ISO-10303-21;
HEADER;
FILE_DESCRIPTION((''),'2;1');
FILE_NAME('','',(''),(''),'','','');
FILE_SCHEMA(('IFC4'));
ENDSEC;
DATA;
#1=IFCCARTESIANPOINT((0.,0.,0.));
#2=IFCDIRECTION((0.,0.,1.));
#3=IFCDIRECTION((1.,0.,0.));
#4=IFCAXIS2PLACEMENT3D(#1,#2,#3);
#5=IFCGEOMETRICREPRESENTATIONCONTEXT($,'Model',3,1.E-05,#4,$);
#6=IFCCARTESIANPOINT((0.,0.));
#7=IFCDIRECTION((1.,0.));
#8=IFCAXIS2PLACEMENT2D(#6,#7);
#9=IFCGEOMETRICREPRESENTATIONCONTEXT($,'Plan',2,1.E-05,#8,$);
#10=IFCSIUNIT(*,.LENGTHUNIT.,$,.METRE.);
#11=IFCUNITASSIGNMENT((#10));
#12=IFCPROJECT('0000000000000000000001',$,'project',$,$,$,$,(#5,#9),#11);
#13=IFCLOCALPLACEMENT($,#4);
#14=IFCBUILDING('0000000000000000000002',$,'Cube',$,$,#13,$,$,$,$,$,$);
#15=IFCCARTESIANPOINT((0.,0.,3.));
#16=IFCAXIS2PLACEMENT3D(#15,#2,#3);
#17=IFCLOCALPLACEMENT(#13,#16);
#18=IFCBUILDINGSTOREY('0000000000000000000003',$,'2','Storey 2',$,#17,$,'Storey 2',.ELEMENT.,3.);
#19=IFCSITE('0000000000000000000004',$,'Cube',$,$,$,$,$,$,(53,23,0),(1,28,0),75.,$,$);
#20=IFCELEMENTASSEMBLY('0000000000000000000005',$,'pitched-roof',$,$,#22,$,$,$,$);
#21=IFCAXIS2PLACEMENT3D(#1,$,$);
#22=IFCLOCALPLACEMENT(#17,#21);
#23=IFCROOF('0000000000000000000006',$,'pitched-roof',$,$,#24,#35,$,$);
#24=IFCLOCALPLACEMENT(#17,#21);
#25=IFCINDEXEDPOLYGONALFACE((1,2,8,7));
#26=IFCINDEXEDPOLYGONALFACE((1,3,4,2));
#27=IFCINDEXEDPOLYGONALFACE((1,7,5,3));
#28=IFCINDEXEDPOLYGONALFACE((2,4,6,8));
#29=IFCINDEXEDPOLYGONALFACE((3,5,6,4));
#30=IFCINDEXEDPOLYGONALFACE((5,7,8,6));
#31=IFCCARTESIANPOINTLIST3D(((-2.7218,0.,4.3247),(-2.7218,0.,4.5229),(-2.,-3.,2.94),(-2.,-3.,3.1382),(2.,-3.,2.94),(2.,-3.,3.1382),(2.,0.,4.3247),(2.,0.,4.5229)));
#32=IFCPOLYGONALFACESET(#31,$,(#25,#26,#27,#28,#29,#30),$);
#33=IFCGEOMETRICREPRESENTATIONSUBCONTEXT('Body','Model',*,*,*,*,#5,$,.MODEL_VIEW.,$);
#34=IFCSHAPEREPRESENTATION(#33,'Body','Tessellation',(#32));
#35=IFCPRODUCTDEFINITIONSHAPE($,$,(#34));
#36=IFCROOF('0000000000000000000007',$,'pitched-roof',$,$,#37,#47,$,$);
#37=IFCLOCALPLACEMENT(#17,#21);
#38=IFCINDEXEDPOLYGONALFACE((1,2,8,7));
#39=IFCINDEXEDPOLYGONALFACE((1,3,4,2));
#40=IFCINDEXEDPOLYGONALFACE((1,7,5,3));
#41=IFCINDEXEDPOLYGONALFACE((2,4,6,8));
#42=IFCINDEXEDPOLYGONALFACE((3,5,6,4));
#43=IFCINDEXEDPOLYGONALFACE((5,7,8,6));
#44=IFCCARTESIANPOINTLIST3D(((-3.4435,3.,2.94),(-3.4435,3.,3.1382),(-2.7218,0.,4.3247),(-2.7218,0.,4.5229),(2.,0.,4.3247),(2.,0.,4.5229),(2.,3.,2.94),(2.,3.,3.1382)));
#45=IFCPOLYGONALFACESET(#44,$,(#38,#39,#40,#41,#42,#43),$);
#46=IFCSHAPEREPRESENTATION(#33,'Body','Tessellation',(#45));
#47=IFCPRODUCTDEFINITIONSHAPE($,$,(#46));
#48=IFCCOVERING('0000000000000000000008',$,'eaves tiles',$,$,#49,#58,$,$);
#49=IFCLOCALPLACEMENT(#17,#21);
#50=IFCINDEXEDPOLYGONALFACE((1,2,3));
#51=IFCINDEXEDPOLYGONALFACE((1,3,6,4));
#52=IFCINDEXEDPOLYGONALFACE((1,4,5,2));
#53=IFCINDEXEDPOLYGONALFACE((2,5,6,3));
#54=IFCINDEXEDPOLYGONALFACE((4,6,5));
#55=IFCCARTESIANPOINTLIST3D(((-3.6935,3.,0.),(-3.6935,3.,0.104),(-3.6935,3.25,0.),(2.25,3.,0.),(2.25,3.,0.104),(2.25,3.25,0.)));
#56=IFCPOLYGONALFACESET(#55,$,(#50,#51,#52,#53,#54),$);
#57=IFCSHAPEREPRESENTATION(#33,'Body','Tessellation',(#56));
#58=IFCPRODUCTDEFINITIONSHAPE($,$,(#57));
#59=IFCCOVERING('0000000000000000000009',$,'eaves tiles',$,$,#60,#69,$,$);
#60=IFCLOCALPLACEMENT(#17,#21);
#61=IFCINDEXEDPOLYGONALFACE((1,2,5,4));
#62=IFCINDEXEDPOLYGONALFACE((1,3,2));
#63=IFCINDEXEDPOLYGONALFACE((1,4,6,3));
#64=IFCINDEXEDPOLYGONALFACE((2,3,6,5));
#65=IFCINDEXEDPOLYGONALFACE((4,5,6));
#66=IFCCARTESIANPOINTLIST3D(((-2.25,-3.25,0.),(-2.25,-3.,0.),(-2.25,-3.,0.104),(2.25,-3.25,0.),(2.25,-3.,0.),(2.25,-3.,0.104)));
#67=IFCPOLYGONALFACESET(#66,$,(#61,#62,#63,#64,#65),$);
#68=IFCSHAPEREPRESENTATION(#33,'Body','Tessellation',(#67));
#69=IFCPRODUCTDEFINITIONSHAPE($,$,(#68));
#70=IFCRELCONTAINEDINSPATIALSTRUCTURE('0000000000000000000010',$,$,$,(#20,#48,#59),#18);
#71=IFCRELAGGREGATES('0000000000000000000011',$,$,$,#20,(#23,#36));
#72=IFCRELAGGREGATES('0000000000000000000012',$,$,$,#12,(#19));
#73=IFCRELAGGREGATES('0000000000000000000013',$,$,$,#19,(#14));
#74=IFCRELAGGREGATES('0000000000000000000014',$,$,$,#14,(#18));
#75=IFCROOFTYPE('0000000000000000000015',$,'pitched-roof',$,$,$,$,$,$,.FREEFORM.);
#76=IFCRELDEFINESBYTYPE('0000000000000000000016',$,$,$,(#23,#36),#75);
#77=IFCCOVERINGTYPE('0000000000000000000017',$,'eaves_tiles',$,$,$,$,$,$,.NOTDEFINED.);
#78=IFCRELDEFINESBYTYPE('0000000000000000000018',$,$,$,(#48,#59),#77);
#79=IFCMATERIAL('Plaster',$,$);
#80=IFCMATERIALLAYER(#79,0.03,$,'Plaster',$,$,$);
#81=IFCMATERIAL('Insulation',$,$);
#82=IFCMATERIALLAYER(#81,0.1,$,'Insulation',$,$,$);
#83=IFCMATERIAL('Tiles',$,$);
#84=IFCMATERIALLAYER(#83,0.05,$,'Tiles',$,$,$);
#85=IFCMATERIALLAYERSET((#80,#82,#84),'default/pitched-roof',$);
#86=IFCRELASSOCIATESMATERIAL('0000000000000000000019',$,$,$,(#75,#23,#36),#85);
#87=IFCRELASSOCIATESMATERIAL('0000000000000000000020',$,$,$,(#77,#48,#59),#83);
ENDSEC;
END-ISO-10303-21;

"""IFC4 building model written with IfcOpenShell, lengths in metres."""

from ifc_helpers import new_model, si_unit, frame, origin, origin_with_axes, origin_2d_with_axis, place, context, subcontext, project, spatial, polyline, outline, extrude, material, layer, layer_set, layer_usage, material_profile, profile_set, profile_usage, type_object, element, aggregate, save


model = new_model("IFC4")

# Units and contexts
model_context = context("Model", 3, precision=1e-05, world=origin_with_axes())
plan_context = context("Plan", 2, precision=1e-05, world=origin_2d_with_axis())
body_context = subcontext(model_context, "Body", "Model", "MODEL_VIEW")
ifc_project = project(units=[si_unit("LENGTHUNIT", "METRE")], contexts=[model_context, plan_context])

# Site, building, storey
site = spatial("IfcSite", under=ifc_project, Name="Cube", RefLatitude=(53, 23, 0), RefLongitude=(1, 28, 0), RefElevation=75.0)
building_placement = place(None, origin_with_axes())
building = spatial("IfcBuilding", under=site, at=building_placement, Name="Cube")
storey_placement = place(building_placement, frame((0.0, 0.0, 3.0), z_axis=(0.0, 0.0, 1.0), x_axis=(1.0, 0.0, 0.0)))
storey = spatial("IfcBuildingStorey", under=building, at=storey_placement, Name="2", Description="Storey 2", LongName="Storey 2", CompositionType="ELEMENT", Elevation=3.0)

# Element assembly, roofs
assembly_placement = place(storey_placement, origin_with_axes())
assembly = element("IfcElementAssembly", 1, at=assembly_placement, inside=storey, Name="pitched-roof")
ifc_material_1 = material(Name="Plaster")
ifc_layer_1 = layer(ifc_material_1, 0.03, Name="Plaster")
ifc_material_2 = material(Name="Insulation")
ifc_layer_2 = layer(ifc_material_2, 0.1, Name="Insulation")
ifc_material_3 = material(Name="Tiles")
ifc_layer_3 = layer(ifc_material_3, 0.05, Name="Tiles")
ifc_layer_set = layer_set([ifc_layer_1, ifc_layer_2, ifc_layer_3], Name="default/pitched-roof")
ifc_layer_usage_1 = layer_usage(ifc_layer_set, "AXIS3", "POSITIVE", 0.0)
roof_type = type_object("IfcRoofType", Name="pitched-roof", PredefinedType="FREEFORM", material=ifc_layer_set)
roof_1_placement = place(assembly_placement, frame((-2.0, -3.0, 2.94), z_axis=(0.0, -0.419069, 0.907954), x_axis=(1.0, 0.0, 0.0)))
roof_1 = element("IfcRoof", 2, at=roof_1_placement, type_object=roof_type, material=ifc_layer_usage_1, Name="pitched-roof", context=body_context, shape_type="SweptSolid", body=[
    extrude(outline(polyline([(0.0, 0.0), (4.0, 0.0), (4.0, 3.3041), (-0.7218, 3.3041), (0.0, 0.0)])), origin(), (0.0, 0.419069, 0.907954), 0.1982),
])
ifc_layer_usage_2 = layer_usage(ifc_layer_set, "AXIS3", "POSITIVE", 0.0)
roof_2_placement = place(assembly_placement, frame((-3.4435, 3.0, 2.94), z_axis=(0.0, 0.419069, 0.907954), x_axis=(-1.0, 0.0, 0.0)))
roof_2 = element("IfcRoof", 3, at=roof_2_placement, type_object=roof_type, material=ifc_layer_usage_2, Name="pitched-roof", context=body_context, shape_type="SweptSolid", body=[
    extrude(outline(polyline([(0.0, 0.0), (-0.7218, 3.3041), (-5.4435, 3.3041), (-5.4435, 0.0), (0.0, 0.0)])), origin(), (0.0, 0.419069, 0.907954), 0.1982),
])
aggregate(assembly, [roof_1, roof_2])

# Coverings
ifc_material_profile_1 = material_profile(ifc_material_3, outline(polyline([(0.25, 0.0), (0.0, 0.0), (0.0, 0.104), (0.25, 0.0)])))
ifc_profile_set_1 = profile_set([ifc_material_profile_1])
ifc_profile_usage_1 = profile_usage(ifc_profile_set_1)
covering_type_1 = type_object("IfcCoveringType", Name="eaves_tiles", PredefinedType="NOTDEFINED", material=ifc_profile_set_1)
covering_1_placement = place(storey_placement, frame((-3.6935, 3.0, 0.0), z_axis=(1.0, 0.0, 0.0), x_axis=(0.0, 1.0, 0.0)))
element("IfcCovering", 4, at=covering_1_placement, inside=storey, type_object=covering_type_1, material=ifc_profile_usage_1, Name="eaves tiles", context=body_context, shape_type="SweptSolid", body=[
    extrude(outline(polyline([(0.25, 0.0), (0.0, 0.0), (0.0, 0.104), (0.25, 0.0)])), origin_with_axes(), (0.0, 0.0, 1.0), 5.9435),
])
ifc_profile_usage_2 = profile_usage(ifc_profile_set_1)
covering_2_placement = place(storey_placement, frame((2.25, -3.0, 0.0), z_axis=(-1.0, 0.0, 0.0), x_axis=(0.0, -1.0, 0.0)))
element("IfcCovering", 5, at=covering_2_placement, inside=storey, type_object=covering_type_1, material=ifc_profile_usage_2, Name="eaves tiles", context=body_context, shape_type="SweptSolid", body=[
    extrude(outline(polyline([(0.25, 0.0), (0.0, 0.0), (0.0, 0.104), (0.25, 0.0)])), origin_with_axes(), (0.0, 0.0, 1.0), 4.5),
])

save(model, "model.ifc")
